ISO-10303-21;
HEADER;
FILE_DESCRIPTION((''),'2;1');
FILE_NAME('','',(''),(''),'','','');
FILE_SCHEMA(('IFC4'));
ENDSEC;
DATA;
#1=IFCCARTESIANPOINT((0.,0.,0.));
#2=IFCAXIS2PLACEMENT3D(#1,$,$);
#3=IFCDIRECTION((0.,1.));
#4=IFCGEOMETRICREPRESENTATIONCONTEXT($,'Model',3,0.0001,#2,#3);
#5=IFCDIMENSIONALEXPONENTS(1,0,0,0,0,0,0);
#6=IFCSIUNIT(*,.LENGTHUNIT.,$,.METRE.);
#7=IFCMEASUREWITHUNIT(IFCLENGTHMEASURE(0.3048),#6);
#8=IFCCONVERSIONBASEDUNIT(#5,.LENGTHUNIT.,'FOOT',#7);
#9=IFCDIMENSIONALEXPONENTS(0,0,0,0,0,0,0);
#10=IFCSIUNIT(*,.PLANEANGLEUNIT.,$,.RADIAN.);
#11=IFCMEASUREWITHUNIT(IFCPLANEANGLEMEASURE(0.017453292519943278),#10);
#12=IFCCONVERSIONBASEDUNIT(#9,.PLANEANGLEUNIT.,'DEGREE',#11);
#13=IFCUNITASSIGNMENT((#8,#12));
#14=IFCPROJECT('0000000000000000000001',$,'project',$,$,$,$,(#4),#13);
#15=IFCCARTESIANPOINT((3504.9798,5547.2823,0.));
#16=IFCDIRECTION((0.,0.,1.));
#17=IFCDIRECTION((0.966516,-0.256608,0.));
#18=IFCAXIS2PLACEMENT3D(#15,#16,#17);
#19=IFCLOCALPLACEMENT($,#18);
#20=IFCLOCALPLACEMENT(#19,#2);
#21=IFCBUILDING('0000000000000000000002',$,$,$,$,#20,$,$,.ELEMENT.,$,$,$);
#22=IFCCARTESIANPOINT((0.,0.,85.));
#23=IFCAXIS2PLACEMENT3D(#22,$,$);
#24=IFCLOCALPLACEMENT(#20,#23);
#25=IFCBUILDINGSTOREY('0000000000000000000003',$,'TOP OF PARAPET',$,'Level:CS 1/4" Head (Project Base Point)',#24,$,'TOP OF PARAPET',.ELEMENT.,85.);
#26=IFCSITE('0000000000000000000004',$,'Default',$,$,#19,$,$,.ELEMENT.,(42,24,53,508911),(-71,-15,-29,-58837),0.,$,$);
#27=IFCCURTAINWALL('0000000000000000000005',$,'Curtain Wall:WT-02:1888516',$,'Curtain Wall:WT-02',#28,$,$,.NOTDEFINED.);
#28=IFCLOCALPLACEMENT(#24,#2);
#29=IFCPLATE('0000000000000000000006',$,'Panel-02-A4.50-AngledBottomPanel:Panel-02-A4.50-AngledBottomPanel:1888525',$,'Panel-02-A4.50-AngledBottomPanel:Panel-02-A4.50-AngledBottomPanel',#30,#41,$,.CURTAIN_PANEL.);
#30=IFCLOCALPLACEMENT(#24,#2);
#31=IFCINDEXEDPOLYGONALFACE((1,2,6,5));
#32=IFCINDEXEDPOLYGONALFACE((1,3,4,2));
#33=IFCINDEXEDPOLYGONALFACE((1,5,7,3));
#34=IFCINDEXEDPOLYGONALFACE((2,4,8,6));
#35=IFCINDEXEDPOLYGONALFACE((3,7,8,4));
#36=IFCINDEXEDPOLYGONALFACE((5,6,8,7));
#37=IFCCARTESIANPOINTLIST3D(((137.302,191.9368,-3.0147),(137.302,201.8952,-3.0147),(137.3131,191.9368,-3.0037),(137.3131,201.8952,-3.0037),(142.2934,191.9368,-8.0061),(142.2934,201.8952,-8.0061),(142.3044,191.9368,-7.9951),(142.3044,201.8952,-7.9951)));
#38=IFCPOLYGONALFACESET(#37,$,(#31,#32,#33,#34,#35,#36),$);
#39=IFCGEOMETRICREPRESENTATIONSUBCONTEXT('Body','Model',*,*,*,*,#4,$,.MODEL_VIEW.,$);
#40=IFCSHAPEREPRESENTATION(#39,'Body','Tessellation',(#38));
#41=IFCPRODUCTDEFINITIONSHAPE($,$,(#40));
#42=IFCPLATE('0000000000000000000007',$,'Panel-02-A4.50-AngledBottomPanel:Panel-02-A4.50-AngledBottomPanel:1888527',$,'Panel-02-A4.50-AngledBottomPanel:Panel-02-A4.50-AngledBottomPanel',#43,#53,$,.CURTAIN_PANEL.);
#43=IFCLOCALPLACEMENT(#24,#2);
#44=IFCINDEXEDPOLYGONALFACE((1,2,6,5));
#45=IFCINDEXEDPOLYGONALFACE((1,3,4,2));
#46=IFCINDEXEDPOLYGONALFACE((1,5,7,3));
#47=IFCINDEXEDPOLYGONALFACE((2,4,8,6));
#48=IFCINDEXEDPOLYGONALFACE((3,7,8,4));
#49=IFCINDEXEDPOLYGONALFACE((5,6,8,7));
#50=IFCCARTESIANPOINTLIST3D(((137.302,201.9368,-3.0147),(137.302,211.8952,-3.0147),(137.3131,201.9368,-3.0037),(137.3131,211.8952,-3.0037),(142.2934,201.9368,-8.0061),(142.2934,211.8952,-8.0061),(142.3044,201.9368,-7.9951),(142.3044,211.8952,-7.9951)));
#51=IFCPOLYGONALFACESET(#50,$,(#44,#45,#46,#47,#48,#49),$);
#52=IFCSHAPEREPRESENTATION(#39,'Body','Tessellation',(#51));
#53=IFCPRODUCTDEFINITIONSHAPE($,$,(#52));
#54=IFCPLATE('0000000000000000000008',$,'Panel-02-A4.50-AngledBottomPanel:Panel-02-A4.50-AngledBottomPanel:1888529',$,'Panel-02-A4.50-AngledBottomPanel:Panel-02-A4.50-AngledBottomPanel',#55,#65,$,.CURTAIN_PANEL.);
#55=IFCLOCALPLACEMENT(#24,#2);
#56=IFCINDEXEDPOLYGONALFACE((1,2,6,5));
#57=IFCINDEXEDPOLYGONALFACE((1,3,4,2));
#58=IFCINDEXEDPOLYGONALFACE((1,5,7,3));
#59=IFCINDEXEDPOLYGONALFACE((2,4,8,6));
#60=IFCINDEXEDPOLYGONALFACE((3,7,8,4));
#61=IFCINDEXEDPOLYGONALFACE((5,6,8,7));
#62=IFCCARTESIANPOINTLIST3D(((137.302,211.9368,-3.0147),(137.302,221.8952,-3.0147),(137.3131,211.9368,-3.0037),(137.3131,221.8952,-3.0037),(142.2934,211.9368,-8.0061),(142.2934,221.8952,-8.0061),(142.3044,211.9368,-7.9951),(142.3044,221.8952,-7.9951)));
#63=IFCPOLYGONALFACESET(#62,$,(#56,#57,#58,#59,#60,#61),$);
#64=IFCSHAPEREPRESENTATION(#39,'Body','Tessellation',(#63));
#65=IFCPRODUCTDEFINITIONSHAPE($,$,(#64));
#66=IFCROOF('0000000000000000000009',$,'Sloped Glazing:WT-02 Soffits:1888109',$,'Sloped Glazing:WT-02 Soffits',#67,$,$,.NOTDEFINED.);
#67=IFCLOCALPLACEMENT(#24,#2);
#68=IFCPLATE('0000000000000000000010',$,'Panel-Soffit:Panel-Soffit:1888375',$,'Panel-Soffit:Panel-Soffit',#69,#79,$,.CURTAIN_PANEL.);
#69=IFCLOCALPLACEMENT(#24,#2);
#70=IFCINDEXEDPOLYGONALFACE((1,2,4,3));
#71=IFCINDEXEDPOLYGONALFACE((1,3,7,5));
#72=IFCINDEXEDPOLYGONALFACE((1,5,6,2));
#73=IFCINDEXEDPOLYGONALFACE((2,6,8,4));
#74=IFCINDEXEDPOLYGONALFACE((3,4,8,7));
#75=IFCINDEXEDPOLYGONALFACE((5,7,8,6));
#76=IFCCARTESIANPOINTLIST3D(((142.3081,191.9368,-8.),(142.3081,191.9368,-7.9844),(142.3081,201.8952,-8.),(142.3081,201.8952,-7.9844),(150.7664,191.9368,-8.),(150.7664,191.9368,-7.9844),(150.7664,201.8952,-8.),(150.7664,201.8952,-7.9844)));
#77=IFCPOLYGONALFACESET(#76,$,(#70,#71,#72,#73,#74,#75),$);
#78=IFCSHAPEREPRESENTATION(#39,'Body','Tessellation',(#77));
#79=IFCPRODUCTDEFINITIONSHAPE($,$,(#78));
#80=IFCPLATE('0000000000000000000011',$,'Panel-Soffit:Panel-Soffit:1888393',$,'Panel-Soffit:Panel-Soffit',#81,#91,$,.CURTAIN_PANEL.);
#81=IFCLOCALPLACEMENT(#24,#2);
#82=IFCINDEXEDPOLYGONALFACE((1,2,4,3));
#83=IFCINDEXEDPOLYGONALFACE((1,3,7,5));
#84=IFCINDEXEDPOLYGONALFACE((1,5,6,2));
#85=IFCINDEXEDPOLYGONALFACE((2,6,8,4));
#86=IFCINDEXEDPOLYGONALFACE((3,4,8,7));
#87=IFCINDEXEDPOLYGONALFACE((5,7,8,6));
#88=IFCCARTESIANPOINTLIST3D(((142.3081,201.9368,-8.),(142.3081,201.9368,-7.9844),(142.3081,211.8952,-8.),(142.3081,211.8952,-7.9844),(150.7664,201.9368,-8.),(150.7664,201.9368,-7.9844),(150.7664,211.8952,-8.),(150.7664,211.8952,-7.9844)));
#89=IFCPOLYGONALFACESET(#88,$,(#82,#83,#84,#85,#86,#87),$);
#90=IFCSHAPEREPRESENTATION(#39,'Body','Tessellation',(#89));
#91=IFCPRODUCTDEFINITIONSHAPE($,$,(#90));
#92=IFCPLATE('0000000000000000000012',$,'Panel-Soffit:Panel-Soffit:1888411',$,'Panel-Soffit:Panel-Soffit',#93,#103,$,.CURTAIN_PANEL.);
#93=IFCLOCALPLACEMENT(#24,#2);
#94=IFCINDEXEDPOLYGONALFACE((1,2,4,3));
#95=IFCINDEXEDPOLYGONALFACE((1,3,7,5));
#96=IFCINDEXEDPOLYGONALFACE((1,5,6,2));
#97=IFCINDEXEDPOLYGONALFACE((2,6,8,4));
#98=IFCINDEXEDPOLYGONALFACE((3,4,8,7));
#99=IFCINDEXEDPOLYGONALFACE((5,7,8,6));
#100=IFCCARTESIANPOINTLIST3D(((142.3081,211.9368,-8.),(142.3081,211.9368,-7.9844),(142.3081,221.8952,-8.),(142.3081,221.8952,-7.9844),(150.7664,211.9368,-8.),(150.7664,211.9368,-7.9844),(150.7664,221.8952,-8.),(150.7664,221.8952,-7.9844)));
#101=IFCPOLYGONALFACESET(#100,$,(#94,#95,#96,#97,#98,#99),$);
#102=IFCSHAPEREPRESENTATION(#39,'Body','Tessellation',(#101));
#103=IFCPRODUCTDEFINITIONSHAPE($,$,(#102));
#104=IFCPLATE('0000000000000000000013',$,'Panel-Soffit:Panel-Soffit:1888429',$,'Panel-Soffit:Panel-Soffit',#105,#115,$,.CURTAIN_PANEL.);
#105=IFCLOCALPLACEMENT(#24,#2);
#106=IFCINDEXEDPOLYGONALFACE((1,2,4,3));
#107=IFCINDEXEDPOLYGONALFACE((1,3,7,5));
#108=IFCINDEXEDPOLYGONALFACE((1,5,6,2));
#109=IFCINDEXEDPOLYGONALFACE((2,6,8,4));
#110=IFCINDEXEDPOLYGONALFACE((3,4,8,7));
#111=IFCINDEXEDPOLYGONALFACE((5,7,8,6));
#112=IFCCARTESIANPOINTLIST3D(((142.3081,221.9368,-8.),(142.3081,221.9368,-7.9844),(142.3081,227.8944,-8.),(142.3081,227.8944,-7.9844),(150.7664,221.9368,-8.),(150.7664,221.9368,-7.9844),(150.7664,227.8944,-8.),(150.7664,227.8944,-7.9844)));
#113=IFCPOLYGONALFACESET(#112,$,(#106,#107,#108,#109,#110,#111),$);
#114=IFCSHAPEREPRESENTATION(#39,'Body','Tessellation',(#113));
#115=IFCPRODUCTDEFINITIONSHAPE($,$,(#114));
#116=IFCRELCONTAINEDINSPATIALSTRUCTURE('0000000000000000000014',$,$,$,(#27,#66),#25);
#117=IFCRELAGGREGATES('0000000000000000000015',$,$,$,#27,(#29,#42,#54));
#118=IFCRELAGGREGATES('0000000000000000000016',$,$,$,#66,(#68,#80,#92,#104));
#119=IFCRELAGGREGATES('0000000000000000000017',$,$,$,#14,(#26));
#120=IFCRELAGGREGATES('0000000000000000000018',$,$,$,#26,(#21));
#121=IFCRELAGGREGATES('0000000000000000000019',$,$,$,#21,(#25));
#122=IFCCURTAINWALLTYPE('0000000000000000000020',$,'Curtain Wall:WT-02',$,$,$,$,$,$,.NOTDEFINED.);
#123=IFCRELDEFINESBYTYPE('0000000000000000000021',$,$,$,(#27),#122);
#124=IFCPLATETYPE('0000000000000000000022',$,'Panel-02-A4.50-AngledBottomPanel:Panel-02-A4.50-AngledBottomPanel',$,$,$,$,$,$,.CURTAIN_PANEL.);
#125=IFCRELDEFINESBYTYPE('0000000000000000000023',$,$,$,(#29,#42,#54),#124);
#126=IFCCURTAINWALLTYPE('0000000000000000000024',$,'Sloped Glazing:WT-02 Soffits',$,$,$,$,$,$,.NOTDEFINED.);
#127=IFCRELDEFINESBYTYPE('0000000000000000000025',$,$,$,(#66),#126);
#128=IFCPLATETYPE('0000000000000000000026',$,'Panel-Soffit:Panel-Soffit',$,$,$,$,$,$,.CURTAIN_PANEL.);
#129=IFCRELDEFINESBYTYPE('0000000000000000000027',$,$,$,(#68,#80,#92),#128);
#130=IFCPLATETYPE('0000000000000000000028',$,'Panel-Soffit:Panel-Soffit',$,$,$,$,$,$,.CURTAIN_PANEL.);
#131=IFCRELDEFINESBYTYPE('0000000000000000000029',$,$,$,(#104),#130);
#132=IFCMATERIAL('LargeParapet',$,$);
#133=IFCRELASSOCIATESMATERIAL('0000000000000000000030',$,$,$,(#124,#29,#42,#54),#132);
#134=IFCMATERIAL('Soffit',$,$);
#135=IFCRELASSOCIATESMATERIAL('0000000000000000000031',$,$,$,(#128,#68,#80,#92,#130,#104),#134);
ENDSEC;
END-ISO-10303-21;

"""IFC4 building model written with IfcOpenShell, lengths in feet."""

from ifc_helpers import new_model, entity, si_unit, converted_unit, direction, frame, origin, place, context, subcontext, project, spatial, indexed_curve, outline, extrude, source, transform, mapped, material, type_object, type_shapes, element, aggregate, save


model = new_model("IFC4")

# Units and contexts
model_context = context("Model", 3, precision=0.0001, world=origin(), true_north=direction((0.0, 1.0)))
body_context = subcontext(model_context, "Body", "Model", "MODEL_VIEW")
ifc_project = project(units=[converted_unit("LENGTHUNIT", "FOOT", entity("IfcLengthMeasure", 0.3048), si_unit("LENGTHUNIT", "METRE"), dimensions=[1, 0, 0, 0, 0, 0, 0]), converted_unit("PLANEANGLEUNIT", "DEGREE", entity("IfcPlaneAngleMeasure", 0.017453292519943278), si_unit("PLANEANGLEUNIT", "RADIAN"), dimensions=[0, 0, 0, 0, 0, 0, 0])], contexts=[model_context])

# Site, building, storey
site_placement = place(None, frame((3504.9798, 5547.2823, 0.0), z_axis=(0.0, 0.0, 1.0), x_axis=(0.966516, -0.256608, 0.0)))
site = spatial("IfcSite", under=ifc_project, at=site_placement, Name="Default", CompositionType="ELEMENT", RefLatitude=(42, 24, 53, 508911), RefLongitude=(-71, -15, -29, -58837), RefElevation=0.0)
building_placement = place(site_placement, origin())
building = spatial("IfcBuilding", under=site, at=building_placement, CompositionType="ELEMENT")
storey_placement = place(building_placement, frame((0.0, 0.0, 85.0)))
storey = spatial("IfcBuildingStorey", under=building, at=storey_placement, Name="TOP OF PARAPET", ObjectType="Level:CS 1/4\" Head (Project Base Point)", LongName="TOP OF PARAPET", CompositionType="ELEMENT", Elevation=85.0)

# Curtain wall, plates
curtain_wall_type_1 = type_object("IfcCurtainWallType", Name="Curtain Wall:WT-02", PredefinedType="NOTDEFINED")
ifc_material_1 = material(Name="LargeParapet")
curtain_wall_1_placement = place(storey_placement, frame((0.0, 0.0, -85.0)))
curtain_wall_1 = element("IfcCurtainWall", 1, at=curtain_wall_1_placement, inside=storey, type_object=curtain_wall_type_1, Name="Curtain Wall:WT-02:1888516", ObjectType="Curtain Wall:WT-02", PredefinedType="NOTDEFINED")
plate_type_1 = type_object("IfcPlateType", Name="Panel-02-A4.50-AngledBottomPanel:Panel-02-A4.50-AngledBottomPanel", PredefinedType="CURTAIN_PANEL", material=ifc_material_1)
shared_shape_1 = source(origin(), body_context, "Body", "SweptSolid", [
    extrude(outline(indexed_curve([(-0.0078, -4.9792), (0.0078, -4.9792), (0.0078, 4.9792), (-0.0078, 4.9792), (-0.0078, -4.9792)], self_intersect=False)), frame((4.9792, 0.0078, 0.0), z_axis=(0.0, 0.0, 1.0), x_axis=(0.0, -1.0, 0.0)), (0.0, 0.0, 1.0), 7.0589),
])
type_shapes(plate_type_1, [shared_shape_1])
plate_1_placement = place(curtain_wall_1_placement, frame((142.3044, 191.9368, 77.0049), z_axis=(-0.707107, 0.0, 0.707107), x_axis=(0.0, 1.0, 0.0)))
plate_1 = element("IfcPlate", 2, at=plate_1_placement, type_object=plate_type_1, material=ifc_material_1, Name="Panel-02-A4.50-AngledBottomPanel:Panel-02-A4.50-AngledBottomPanel:1888525", ObjectType="Panel-02-A4.50-AngledBottomPanel:Panel-02-A4.50-AngledBottomPanel", PredefinedType="CURTAIN_PANEL", context=body_context, shape_type="MappedRepresentation", body=[
    mapped(shared_shape_1, transform((0.0, 0.0, 0.0), scale=1.0)),
])
plate_2_placement = place(curtain_wall_1_placement, frame((142.3044, 201.9368, 77.0049), z_axis=(-0.707107, 0.0, 0.707107), x_axis=(0.0, 1.0, 0.0)))
plate_2 = element("IfcPlate", 3, at=plate_2_placement, type_object=plate_type_1, material=ifc_material_1, Name="Panel-02-A4.50-AngledBottomPanel:Panel-02-A4.50-AngledBottomPanel:1888527", ObjectType="Panel-02-A4.50-AngledBottomPanel:Panel-02-A4.50-AngledBottomPanel", PredefinedType="CURTAIN_PANEL", context=body_context, shape_type="MappedRepresentation", body=[
    mapped(shared_shape_1, transform((0.0, 0.0, 0.0), scale=1.0)),
])
plate_3_placement = place(curtain_wall_1_placement, frame((142.3044, 211.9368, 77.0049), z_axis=(-0.707107, 0.0, 0.707107), x_axis=(0.0, 1.0, 0.0)))
plate_3 = element("IfcPlate", 4, at=plate_3_placement, type_object=plate_type_1, material=ifc_material_1, Name="Panel-02-A4.50-AngledBottomPanel:Panel-02-A4.50-AngledBottomPanel:1888529", ObjectType="Panel-02-A4.50-AngledBottomPanel:Panel-02-A4.50-AngledBottomPanel", PredefinedType="CURTAIN_PANEL", context=body_context, shape_type="MappedRepresentation", body=[
    mapped(shared_shape_1, transform((0.0, 0.0, 0.0), scale=1.0)),
])
aggregate(curtain_wall_1, [plate_1, plate_2, plate_3])

# Roof, plates
curtain_wall_type_2 = type_object("IfcCurtainWallType", Name="Sloped Glazing:WT-02 Soffits", PredefinedType="NOTDEFINED")
roof_placement = place(storey_placement, frame((0.0, 0.0, -85.0)))
roof = element("IfcRoof", 5, at=roof_placement, inside=storey, type_object=curtain_wall_type_2, Name="Sloped Glazing:WT-02 Soffits:1888109", ObjectType="Sloped Glazing:WT-02 Soffits", PredefinedType="NOTDEFINED")
ifc_material_2 = material(Name="Soffit")
plate_type_2 = type_object("IfcPlateType", Name="Panel-Soffit:Panel-Soffit", PredefinedType="CURTAIN_PANEL", material=ifc_material_2)
shared_shape_2 = source(origin(), body_context, "Body", "SweptSolid", [
    extrude(outline(indexed_curve([(-0.0078, -4.2292), (0.0078, -4.2292), (0.0078, 4.2292), (-0.0078, 4.2292), (-0.0078, -4.2292)], self_intersect=False)), frame((4.2292, 0.0078, 0.0), z_axis=(0.0, 0.0, 1.0), x_axis=(0.0, -1.0, 0.0)), (0.0, 0.0, 1.0), 9.9583),
])
type_shapes(plate_type_2, [shared_shape_2])
plate_4_placement = place(roof_placement, frame((142.3081, 191.9368, 77.0156), z_axis=(0.0, 1.0, 0.0), x_axis=(1.0, 0.0, 0.0)))
plate_4 = element("IfcPlate", 6, at=plate_4_placement, type_object=plate_type_2, material=ifc_material_2, Name="Panel-Soffit:Panel-Soffit:1888375", ObjectType="Panel-Soffit:Panel-Soffit", PredefinedType="CURTAIN_PANEL", context=body_context, shape_type="MappedRepresentation", body=[
    mapped(shared_shape_2, transform((0.0, 0.0, 0.0), scale=1.0)),
])
plate_5_placement = place(roof_placement, frame((142.3081, 201.9368, 77.0156), z_axis=(0.0, 1.0, 0.0), x_axis=(1.0, 0.0, 0.0)))
plate_5 = element("IfcPlate", 7, at=plate_5_placement, type_object=plate_type_2, material=ifc_material_2, Name="Panel-Soffit:Panel-Soffit:1888393", ObjectType="Panel-Soffit:Panel-Soffit", PredefinedType="CURTAIN_PANEL", context=body_context, shape_type="MappedRepresentation", body=[
    mapped(shared_shape_2, transform((0.0, 0.0, 0.0), scale=1.0)),
])
plate_6_placement = place(roof_placement, frame((142.3081, 211.9368, 77.0156), z_axis=(0.0, 1.0, 0.0), x_axis=(1.0, 0.0, 0.0)))
plate_6 = element("IfcPlate", 8, at=plate_6_placement, type_object=plate_type_2, material=ifc_material_2, Name="Panel-Soffit:Panel-Soffit:1888411", ObjectType="Panel-Soffit:Panel-Soffit", PredefinedType="CURTAIN_PANEL", context=body_context, shape_type="MappedRepresentation", body=[
    mapped(shared_shape_2, transform((0.0, 0.0, 0.0), scale=1.0)),
])
plate_type_3 = type_object("IfcPlateType", Name="Panel-Soffit:Panel-Soffit", PredefinedType="CURTAIN_PANEL", material=ifc_material_2)
shared_shape_3 = source(origin(), body_context, "Body", "SweptSolid", [
    extrude(outline(indexed_curve([(-0.0078, -4.2292), (0.0078, -4.2292), (0.0078, 4.2292), (-0.0078, 4.2292), (-0.0078, -4.2292)], self_intersect=False)), frame((4.2292, 0.0078, 0.0), z_axis=(0.0, 0.0, 1.0), x_axis=(0.0, -1.0, 0.0)), (0.0, 0.0, 1.0), 5.9576),
])
type_shapes(plate_type_3, [shared_shape_3])
plate_7_placement = place(roof_placement, frame((142.3081, 221.9368, 77.0156), z_axis=(0.0, 1.0, 0.0), x_axis=(1.0, 0.0, 0.0)))
plate_7 = element("IfcPlate", 9, at=plate_7_placement, type_object=plate_type_3, material=ifc_material_2, Name="Panel-Soffit:Panel-Soffit:1888429", ObjectType="Panel-Soffit:Panel-Soffit", PredefinedType="CURTAIN_PANEL", context=body_context, shape_type="MappedRepresentation", body=[
    mapped(shared_shape_3, transform((0.0, 0.0, 0.0), scale=1.0)),
])
aggregate(roof, [plate_4, plate_5, plate_6, plate_7])

save(model, "model.ifc")
